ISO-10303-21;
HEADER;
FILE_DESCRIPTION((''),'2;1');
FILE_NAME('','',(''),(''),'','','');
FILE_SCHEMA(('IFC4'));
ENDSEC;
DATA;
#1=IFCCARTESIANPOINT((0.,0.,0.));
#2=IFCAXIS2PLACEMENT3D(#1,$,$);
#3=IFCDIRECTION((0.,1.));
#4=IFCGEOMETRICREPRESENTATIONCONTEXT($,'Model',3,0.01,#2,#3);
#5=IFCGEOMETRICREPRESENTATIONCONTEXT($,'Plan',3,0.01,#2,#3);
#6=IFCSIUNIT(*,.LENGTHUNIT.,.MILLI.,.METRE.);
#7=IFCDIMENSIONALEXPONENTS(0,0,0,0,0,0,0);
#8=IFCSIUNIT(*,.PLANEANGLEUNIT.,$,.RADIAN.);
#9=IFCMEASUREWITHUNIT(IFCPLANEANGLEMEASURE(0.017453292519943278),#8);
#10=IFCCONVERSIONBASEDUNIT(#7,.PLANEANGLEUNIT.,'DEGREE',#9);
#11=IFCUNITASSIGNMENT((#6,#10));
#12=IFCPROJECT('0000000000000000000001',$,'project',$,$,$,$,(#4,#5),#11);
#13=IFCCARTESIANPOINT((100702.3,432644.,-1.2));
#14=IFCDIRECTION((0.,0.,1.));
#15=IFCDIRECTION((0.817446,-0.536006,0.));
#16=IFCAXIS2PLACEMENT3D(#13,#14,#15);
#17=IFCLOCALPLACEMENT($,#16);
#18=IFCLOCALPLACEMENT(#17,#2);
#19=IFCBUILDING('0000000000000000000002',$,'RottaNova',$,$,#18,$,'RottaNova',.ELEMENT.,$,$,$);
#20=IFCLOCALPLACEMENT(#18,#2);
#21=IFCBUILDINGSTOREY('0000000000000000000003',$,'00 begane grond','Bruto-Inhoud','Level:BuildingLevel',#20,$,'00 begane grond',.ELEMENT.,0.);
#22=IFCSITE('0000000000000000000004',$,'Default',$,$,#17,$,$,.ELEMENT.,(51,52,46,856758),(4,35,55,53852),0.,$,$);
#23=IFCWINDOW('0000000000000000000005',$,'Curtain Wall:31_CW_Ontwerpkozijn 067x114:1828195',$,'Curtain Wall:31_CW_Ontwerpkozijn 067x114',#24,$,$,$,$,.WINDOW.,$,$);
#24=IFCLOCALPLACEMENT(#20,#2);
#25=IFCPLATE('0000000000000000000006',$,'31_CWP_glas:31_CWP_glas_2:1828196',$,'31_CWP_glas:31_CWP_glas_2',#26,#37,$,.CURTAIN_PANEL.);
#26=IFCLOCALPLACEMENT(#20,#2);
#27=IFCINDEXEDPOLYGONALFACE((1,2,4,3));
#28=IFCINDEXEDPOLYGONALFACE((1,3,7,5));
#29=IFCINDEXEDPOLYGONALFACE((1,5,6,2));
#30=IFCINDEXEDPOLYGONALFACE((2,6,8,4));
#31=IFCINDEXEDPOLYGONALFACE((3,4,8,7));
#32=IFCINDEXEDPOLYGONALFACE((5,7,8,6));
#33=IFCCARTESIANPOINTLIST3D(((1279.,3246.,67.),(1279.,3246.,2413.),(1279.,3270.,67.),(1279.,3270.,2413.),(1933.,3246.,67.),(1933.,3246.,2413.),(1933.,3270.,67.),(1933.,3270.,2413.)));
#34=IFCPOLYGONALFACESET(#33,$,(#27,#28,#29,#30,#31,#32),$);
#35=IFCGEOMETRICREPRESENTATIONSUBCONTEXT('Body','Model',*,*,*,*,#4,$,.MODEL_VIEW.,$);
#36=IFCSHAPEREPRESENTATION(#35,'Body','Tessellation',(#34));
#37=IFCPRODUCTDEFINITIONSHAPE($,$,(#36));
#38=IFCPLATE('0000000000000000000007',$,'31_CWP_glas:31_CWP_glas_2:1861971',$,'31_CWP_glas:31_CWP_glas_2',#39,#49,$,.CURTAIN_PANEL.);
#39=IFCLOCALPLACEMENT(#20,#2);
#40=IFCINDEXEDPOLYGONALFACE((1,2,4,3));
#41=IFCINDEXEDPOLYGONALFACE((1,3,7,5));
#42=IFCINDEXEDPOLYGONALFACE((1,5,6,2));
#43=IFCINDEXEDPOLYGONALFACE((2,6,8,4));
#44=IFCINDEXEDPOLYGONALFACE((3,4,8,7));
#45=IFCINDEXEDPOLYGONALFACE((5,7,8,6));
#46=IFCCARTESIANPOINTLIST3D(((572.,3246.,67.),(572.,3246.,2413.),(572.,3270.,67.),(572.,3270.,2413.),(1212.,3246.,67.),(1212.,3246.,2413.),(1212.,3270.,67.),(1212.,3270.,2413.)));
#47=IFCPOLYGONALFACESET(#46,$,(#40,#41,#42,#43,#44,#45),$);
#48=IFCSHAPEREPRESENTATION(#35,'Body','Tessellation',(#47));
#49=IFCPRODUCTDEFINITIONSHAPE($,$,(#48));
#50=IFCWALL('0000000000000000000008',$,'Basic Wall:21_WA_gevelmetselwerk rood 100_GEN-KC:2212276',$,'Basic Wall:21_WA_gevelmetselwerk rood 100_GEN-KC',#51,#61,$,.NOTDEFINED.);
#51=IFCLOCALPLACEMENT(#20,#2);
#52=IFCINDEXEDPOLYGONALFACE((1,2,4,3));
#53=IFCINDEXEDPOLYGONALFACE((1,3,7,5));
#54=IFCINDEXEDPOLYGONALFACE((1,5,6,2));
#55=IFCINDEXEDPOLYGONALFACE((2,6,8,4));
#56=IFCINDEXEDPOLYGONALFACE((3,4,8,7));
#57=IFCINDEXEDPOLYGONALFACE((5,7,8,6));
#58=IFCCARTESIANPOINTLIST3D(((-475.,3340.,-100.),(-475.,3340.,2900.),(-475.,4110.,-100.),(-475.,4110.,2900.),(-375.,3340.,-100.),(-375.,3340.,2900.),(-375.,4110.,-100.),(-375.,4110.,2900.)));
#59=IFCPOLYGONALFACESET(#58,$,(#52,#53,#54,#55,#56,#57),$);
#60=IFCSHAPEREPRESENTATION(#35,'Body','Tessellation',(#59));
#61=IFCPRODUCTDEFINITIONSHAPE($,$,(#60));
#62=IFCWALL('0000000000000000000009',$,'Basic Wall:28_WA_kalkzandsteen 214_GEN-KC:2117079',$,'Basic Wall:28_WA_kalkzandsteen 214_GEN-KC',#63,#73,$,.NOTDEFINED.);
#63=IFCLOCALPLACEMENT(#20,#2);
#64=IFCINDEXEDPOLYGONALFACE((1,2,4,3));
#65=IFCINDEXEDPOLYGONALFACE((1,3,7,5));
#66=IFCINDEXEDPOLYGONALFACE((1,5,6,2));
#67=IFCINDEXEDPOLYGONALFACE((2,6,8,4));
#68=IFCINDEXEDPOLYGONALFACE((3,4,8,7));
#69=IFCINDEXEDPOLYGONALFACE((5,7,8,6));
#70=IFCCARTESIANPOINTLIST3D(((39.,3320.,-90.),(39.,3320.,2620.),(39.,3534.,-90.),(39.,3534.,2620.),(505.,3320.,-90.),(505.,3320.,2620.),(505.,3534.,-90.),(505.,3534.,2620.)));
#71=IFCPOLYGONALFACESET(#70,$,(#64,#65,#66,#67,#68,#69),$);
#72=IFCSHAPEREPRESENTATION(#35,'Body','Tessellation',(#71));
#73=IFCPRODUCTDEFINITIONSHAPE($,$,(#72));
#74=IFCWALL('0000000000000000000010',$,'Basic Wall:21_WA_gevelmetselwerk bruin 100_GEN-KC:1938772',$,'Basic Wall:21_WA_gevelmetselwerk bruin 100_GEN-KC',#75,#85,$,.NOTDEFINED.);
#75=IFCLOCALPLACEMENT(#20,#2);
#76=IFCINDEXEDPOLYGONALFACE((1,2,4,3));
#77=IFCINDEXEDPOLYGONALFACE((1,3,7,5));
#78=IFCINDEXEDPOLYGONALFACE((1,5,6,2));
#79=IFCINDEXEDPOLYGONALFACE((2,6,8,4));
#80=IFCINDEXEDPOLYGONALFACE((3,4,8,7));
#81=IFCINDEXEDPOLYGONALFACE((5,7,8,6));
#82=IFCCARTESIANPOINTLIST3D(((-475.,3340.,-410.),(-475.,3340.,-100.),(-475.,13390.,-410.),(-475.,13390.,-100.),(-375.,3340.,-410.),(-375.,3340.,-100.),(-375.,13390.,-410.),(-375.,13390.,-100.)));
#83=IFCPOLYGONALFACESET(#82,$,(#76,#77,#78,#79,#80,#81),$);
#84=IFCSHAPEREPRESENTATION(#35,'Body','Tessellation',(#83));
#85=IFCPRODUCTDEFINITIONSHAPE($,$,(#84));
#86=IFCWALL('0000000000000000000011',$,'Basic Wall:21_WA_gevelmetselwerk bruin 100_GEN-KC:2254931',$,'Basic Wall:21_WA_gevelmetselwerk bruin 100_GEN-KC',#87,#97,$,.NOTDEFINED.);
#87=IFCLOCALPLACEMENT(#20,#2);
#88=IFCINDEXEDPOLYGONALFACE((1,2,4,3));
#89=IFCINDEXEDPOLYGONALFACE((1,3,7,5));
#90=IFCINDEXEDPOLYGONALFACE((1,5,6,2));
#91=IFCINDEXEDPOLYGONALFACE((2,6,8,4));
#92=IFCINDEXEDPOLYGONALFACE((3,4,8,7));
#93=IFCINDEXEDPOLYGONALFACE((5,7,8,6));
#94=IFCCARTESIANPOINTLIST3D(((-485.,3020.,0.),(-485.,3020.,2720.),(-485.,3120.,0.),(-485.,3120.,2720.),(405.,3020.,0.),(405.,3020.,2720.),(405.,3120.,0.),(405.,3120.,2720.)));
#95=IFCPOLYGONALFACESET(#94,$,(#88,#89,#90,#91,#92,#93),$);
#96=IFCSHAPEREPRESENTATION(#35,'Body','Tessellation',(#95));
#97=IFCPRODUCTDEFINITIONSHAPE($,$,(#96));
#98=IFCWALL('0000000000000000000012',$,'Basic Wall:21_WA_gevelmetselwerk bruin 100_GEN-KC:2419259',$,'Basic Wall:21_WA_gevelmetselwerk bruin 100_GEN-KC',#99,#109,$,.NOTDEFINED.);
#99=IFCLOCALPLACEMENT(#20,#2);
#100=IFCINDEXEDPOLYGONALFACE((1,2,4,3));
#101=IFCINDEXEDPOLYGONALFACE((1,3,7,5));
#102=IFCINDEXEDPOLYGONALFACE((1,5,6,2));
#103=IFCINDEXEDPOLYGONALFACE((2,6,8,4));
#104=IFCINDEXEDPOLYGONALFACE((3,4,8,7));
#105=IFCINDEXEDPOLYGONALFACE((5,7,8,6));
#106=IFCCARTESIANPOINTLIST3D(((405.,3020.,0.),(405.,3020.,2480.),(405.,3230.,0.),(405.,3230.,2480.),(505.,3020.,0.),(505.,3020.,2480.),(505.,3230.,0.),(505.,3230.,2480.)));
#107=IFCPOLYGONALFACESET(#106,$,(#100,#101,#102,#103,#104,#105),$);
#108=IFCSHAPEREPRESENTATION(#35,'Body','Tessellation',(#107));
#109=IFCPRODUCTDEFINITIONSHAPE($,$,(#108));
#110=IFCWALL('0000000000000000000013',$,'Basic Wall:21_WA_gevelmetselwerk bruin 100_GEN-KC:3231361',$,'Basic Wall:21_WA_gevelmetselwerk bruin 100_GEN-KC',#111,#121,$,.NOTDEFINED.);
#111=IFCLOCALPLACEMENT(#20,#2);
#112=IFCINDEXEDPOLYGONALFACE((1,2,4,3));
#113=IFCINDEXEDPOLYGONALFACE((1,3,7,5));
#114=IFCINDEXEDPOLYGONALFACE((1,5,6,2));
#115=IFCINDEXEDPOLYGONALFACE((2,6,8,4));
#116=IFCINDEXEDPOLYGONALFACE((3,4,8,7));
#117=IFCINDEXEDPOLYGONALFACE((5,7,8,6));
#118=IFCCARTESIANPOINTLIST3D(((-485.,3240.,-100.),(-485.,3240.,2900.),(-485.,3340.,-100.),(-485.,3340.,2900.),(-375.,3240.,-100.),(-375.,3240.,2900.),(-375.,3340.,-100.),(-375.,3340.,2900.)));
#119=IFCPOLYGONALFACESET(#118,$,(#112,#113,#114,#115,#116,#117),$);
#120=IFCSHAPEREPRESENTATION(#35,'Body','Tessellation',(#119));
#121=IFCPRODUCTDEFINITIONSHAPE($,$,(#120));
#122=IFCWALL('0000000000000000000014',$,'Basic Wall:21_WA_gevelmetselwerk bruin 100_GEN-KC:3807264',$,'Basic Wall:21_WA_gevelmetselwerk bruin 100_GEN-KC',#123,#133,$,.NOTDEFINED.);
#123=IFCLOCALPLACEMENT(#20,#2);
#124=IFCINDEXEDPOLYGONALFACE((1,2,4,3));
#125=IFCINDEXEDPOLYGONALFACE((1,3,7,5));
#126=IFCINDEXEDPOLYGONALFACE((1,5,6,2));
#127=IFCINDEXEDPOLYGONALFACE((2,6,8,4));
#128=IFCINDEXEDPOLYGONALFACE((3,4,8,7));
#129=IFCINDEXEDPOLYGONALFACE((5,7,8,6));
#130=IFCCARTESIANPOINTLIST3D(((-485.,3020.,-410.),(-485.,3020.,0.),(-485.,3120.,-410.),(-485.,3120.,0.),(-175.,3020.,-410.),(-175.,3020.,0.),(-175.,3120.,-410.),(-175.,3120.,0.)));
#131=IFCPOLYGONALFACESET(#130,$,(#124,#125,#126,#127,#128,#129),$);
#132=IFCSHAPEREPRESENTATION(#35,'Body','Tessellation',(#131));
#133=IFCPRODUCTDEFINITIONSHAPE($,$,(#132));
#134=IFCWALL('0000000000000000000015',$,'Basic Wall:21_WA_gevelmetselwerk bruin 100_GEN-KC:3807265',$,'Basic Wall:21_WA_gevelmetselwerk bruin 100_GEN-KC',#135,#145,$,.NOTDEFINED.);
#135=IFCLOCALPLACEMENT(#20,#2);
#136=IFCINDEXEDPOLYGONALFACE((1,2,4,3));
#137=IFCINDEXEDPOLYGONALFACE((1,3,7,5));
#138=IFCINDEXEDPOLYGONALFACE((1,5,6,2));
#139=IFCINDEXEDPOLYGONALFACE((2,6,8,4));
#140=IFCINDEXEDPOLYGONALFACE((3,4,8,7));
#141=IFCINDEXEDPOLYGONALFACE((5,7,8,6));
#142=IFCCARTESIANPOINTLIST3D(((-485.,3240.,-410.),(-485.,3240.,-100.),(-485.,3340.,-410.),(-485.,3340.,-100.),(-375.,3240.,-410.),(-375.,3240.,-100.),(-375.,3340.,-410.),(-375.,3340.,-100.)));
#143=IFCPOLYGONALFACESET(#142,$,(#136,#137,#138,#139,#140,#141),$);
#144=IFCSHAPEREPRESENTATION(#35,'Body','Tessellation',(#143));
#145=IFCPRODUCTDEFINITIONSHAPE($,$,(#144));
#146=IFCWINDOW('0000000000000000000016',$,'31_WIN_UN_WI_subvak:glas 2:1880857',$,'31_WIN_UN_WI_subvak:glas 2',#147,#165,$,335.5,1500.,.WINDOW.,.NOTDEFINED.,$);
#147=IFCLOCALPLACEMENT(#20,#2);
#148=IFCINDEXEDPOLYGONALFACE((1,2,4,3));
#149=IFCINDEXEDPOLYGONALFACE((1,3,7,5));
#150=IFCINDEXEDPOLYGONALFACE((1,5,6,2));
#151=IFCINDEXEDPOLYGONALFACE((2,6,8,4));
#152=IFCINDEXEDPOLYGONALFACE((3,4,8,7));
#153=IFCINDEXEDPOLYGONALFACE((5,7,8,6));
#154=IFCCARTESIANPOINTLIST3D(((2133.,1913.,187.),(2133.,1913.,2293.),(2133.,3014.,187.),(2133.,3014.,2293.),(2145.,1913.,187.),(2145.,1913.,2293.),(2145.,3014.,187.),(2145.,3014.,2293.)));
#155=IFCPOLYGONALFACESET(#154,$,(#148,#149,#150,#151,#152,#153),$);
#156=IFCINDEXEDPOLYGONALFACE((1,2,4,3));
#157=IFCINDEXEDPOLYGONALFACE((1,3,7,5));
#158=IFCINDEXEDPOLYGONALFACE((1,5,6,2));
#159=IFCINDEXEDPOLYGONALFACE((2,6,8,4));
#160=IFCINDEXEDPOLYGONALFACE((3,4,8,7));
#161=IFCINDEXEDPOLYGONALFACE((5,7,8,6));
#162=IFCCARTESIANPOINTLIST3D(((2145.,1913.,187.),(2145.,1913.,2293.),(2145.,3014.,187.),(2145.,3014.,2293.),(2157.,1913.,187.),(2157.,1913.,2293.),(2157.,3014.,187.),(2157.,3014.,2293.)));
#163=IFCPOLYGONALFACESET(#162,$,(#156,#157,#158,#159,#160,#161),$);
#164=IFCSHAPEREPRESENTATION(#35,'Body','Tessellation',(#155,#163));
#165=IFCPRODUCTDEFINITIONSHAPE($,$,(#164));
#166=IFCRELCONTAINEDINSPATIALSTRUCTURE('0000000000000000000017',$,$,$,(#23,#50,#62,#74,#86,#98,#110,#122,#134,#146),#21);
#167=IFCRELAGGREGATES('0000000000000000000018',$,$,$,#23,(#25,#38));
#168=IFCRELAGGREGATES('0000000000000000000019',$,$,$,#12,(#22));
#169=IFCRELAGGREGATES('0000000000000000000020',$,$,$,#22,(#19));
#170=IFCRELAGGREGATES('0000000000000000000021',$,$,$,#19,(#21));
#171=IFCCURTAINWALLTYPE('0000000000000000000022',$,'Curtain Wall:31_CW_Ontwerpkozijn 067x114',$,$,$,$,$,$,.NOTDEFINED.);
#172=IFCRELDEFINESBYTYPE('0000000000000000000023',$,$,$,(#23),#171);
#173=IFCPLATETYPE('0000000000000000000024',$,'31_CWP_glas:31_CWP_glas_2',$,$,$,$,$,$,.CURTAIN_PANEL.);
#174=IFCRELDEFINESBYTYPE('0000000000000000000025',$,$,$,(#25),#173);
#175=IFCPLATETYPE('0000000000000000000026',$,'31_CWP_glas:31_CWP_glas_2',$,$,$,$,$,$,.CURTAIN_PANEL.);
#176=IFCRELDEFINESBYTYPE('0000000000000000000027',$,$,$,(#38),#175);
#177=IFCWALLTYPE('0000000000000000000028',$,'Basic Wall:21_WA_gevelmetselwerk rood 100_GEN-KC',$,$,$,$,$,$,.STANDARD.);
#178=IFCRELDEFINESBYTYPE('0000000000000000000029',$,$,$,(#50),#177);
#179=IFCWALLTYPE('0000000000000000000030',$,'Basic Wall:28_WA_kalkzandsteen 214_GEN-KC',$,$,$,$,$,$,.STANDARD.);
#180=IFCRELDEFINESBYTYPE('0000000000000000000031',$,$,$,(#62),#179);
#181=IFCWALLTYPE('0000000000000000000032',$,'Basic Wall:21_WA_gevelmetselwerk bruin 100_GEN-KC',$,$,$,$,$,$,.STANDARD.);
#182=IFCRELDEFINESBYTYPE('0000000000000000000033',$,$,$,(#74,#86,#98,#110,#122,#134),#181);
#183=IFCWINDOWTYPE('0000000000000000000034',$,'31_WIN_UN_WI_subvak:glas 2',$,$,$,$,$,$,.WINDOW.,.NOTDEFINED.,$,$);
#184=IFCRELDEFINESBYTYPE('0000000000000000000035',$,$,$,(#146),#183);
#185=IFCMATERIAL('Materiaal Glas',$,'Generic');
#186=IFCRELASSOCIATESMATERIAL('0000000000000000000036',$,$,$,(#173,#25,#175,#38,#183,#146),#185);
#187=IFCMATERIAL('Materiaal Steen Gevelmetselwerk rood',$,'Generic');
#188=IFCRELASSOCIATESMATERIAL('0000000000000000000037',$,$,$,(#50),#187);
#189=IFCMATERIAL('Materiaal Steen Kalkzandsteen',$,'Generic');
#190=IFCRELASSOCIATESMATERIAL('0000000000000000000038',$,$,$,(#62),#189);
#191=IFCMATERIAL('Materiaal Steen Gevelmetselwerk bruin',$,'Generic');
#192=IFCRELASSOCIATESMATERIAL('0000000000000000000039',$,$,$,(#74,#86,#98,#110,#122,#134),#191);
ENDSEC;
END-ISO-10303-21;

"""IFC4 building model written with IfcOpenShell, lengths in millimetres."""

from ifc_helpers import new_model, entity, si_unit, converted_unit, direction, frame, origin, place, context, subcontext, project, spatial, indexed_curve, outline, extrude, source, transform, mapped, material, type_object, type_shapes, element, aggregate, save


model = new_model("IFC4")

# Units and contexts
model_context = context("Model", 3, precision=0.01, world=origin(), true_north=direction((0.0, 1.0)))
plan_context = context("Plan", 3, precision=0.01, world=origin(), true_north=direction((0.0, 1.0)))
body_context = subcontext(model_context, "Body", "Model", "MODEL_VIEW")
ifc_project = project(units=[si_unit("LENGTHUNIT", "METRE", prefix="MILLI"), converted_unit("PLANEANGLEUNIT", "DEGREE", entity("IfcPlaneAngleMeasure", 0.017453292519943278), si_unit("PLANEANGLEUNIT", "RADIAN"), dimensions=[0, 0, 0, 0, 0, 0, 0])], contexts=[model_context, plan_context])

# Site, building, storey
site_placement = place(None, frame((100702.3, 432644.0, -1.2), z_axis=(0.0, 0.0, 1.0), x_axis=(0.817446, -0.536006, 0.0)))
site = spatial("IfcSite", under=ifc_project, at=site_placement, Name="Default", CompositionType="ELEMENT", RefLatitude=(51, 52, 46, 856758), RefLongitude=(4, 35, 55, 53852), RefElevation=0.0)
building_placement = place(site_placement, origin())
building = spatial("IfcBuilding", under=site, at=building_placement, Name="RottaNova", LongName="RottaNova", CompositionType="ELEMENT")
storey_placement = place(building_placement, origin())
storey = spatial("IfcBuildingStorey", under=building, at=storey_placement, Name="00 begane grond", Description="Bruto-Inhoud", ObjectType="Level:BuildingLevel", LongName="00 begane grond", CompositionType="ELEMENT", Elevation=0.0)

# Window
curtain_wall_type = type_object("IfcCurtainWallType", Name="Curtain Wall:31_CW_Ontwerpkozijn 067x114", PredefinedType="NOTDEFINED")
window_1_placement = place(storey_placement, origin())
window_1 = element("IfcWindow", 1, at=window_1_placement, inside=storey, type_object=curtain_wall_type, Name="Curtain Wall:31_CW_Ontwerpkozijn 067x114:1828195", ObjectType="Curtain Wall:31_CW_Ontwerpkozijn 067x114", PredefinedType="WINDOW")

# Plates
ifc_material_1 = material(Name="Materiaal Glas", Category="Generic")
plate_type_1 = type_object("IfcPlateType", Name="31_CWP_glas:31_CWP_glas_2", PredefinedType="CURTAIN_PANEL", material=ifc_material_1)
shared_shape_1 = source(origin(), body_context, "Body", "SweptSolid", [
    extrude(outline(indexed_curve([(-12.0, -327.0), (12.0, -327.0), (12.0, 327.0), (-12.0, 327.0), (-12.0, -327.0)], self_intersect=False)), frame((0.0, 57.0, 0.0), z_axis=(0.0, 0.0, 1.0), x_axis=(0.0, 1.0, 0.0)), (0.0, 0.0, 1.0), 2346.0),
])
type_shapes(plate_type_1, [shared_shape_1])
plate_1_placement = place(window_1_placement, frame((1606.0, 3315.0, 67.0), z_axis=(0.0, 0.0, 1.0), x_axis=(-1.0, 0.0, 0.0)))
plate_1 = element("IfcPlate", 2, at=plate_1_placement, type_object=plate_type_1, material=ifc_material_1, Name="31_CWP_glas:31_CWP_glas_2:1828196", ObjectType="31_CWP_glas:31_CWP_glas_2", PredefinedType="CURTAIN_PANEL", context=body_context, shape_type="MappedRepresentation", body=[
    mapped(shared_shape_1, transform((0.0, 0.0, 0.0), scale=1.0)),
])
plate_type_2 = type_object("IfcPlateType", Name="31_CWP_glas:31_CWP_glas_2", PredefinedType="CURTAIN_PANEL", material=ifc_material_1)
shared_shape_2 = source(origin(), body_context, "Body", "SweptSolid", [
    extrude(outline(indexed_curve([(-12.0, -320.0), (12.0, -320.0), (12.0, 320.0), (-12.0, 320.0), (-12.0, -320.0)], self_intersect=False)), frame((0.0, 57.0, 0.0), z_axis=(0.0, 0.0, 1.0), x_axis=(0.0, 1.0, 0.0)), (0.0, 0.0, 1.0), 2346.0),
])
type_shapes(plate_type_2, [shared_shape_2])
plate_2_placement = place(window_1_placement, frame((892.0, 3315.0, 67.0), z_axis=(0.0, 0.0, 1.0), x_axis=(-1.0, 0.0, 0.0)))
plate_2 = element("IfcPlate", 3, at=plate_2_placement, type_object=plate_type_2, material=ifc_material_1, Name="31_CWP_glas:31_CWP_glas_2:1861971", ObjectType="31_CWP_glas:31_CWP_glas_2", PredefinedType="CURTAIN_PANEL", context=body_context, shape_type="MappedRepresentation", body=[
    mapped(shared_shape_2, transform((0.0, 0.0, 0.0), scale=1.0)),
])
aggregate(window_1, [plate_1, plate_2])

# Walls
ifc_material_2 = material(Name="Materiaal Steen Gevelmetselwerk rood", Category="Generic")
wall_type_1 = type_object("IfcWallType", Name="Basic Wall:21_WA_gevelmetselwerk rood 100_GEN-KC", PredefinedType="STANDARD")
wall_1_placement = place(storey_placement, frame((-425.0, 3340.0, -100.0), z_axis=(0.0, 0.0, 1.0), x_axis=(0.0, 1.0, 0.0)))
element("IfcWall", 4, at=wall_1_placement, inside=storey, type_object=wall_type_1, material=ifc_material_2, Name="Basic Wall:21_WA_gevelmetselwerk rood 100_GEN-KC:2212276", ObjectType="Basic Wall:21_WA_gevelmetselwerk rood 100_GEN-KC", PredefinedType="NOTDEFINED", context=body_context, shape_type="SweptSolid", body=[
    extrude(outline(indexed_curve([(770.0, 50.0), (0.0, 50.0), (0.0, -50.0), (770.0, -50.0), (770.0, 50.0)], self_intersect=False)), origin(), (0.0, 0.0, 1.0), 3000.0),
])
ifc_material_3 = material(Name="Materiaal Steen Kalkzandsteen", Category="Generic")
wall_type_2 = type_object("IfcWallType", Name="Basic Wall:28_WA_kalkzandsteen 214_GEN-KC", PredefinedType="STANDARD")
wall_2_placement = place(storey_placement, frame((39.0, 3427.0, -90.0)))
element("IfcWall", 5, at=wall_2_placement, inside=storey, type_object=wall_type_2, material=ifc_material_3, Name="Basic Wall:28_WA_kalkzandsteen 214_GEN-KC:2117079", ObjectType="Basic Wall:28_WA_kalkzandsteen 214_GEN-KC", PredefinedType="NOTDEFINED", context=body_context, shape_type="SweptSolid", body=[
    extrude(outline(indexed_curve([(466.0, 107.0), (0.0, 107.0), (0.0, -107.0), (466.0, -107.0), (466.0, 107.0)], self_intersect=False)), origin(), (0.0, 0.0, 1.0), 2710.0),
])
ifc_material_4 = material(Name="Materiaal Steen Gevelmetselwerk bruin", Category="Generic")
wall_type_3 = type_object("IfcWallType", Name="Basic Wall:21_WA_gevelmetselwerk bruin 100_GEN-KC", PredefinedType="STANDARD")
wall_3_placement = place(storey_placement, frame((-425.0, 3340.0, -410.0), z_axis=(0.0, 0.0, 1.0), x_axis=(0.0, 1.0, 0.0)))
element("IfcWall", 6, at=wall_3_placement, inside=storey, type_object=wall_type_3, material=ifc_material_4, Name="Basic Wall:21_WA_gevelmetselwerk bruin 100_GEN-KC:1938772", ObjectType="Basic Wall:21_WA_gevelmetselwerk bruin 100_GEN-KC", PredefinedType="NOTDEFINED", context=body_context, shape_type="SweptSolid", body=[
    extrude(outline(indexed_curve([(10050.0, 50.0), (0.0, 50.0), (0.0, -50.0), (10050.0, -50.0), (10050.0, 50.0)], self_intersect=False)), origin(), (0.0, 0.0, 1.0), 310.0),
])
wall_4_placement = place(storey_placement, frame((405.0, 3070.0, 0.0), z_axis=(0.0, 0.0, 1.0), x_axis=(-1.0, 0.0, 0.0)))
element("IfcWall", 7, at=wall_4_placement, inside=storey, type_object=wall_type_3, material=ifc_material_4, Name="Basic Wall:21_WA_gevelmetselwerk bruin 100_GEN-KC:2254931", ObjectType="Basic Wall:21_WA_gevelmetselwerk bruin 100_GEN-KC", PredefinedType="NOTDEFINED", context=body_context, shape_type="SweptSolid", body=[
    extrude(outline(indexed_curve([(890.0, 50.0), (0.0, 50.0), (0.0, -50.0), (890.0, -50.0), (890.0, 50.0)], self_intersect=False)), origin(), (0.0, 0.0, 1.0), 2720.0),
])
wall_5_placement = place(storey_placement, frame((455.0, 3230.0, 0.0), z_axis=(0.0, 0.0, 1.0), x_axis=(0.0, -1.0, 0.0)))
element("IfcWall", 8, at=wall_5_placement, inside=storey, type_object=wall_type_3, material=ifc_material_4, Name="Basic Wall:21_WA_gevelmetselwerk bruin 100_GEN-KC:2419259", ObjectType="Basic Wall:21_WA_gevelmetselwerk bruin 100_GEN-KC", PredefinedType="NOTDEFINED", context=body_context, shape_type="SweptSolid", body=[
    extrude(outline(indexed_curve([(210.0, 50.0), (0.0, 50.0), (0.0, -50.0), (210.0, -50.0), (210.0, 50.0)], self_intersect=False)), origin(), (0.0, 0.0, 1.0), 2480.0),
])
wall_6_placement = place(storey_placement, frame((-485.0, 3290.0, -100.0)))
element("IfcWall", 9, at=wall_6_placement, inside=storey, type_object=wall_type_3, material=ifc_material_4, Name="Basic Wall:21_WA_gevelmetselwerk bruin 100_GEN-KC:3231361", ObjectType="Basic Wall:21_WA_gevelmetselwerk bruin 100_GEN-KC", PredefinedType="NOTDEFINED", context=body_context, shape_type="SweptSolid", body=[
    extrude(outline(indexed_curve([(110.0, 50.0), (0.0, 50.0), (0.0, -50.0), (110.0, -50.0), (110.0, 50.0)], self_intersect=False)), origin(), (0.0, 0.0, 1.0), 3000.0),
])
wall_7_placement = place(storey_placement, frame((-175.0, 3070.0, -410.0), z_axis=(0.0, 0.0, 1.0), x_axis=(-1.0, 0.0, 0.0)))
element("IfcWall", 10, at=wall_7_placement, inside=storey, type_object=wall_type_3, material=ifc_material_4, Name="Basic Wall:21_WA_gevelmetselwerk bruin 100_GEN-KC:3807264", ObjectType="Basic Wall:21_WA_gevelmetselwerk bruin 100_GEN-KC", PredefinedType="NOTDEFINED", context=body_context, shape_type="SweptSolid", body=[
    extrude(outline(indexed_curve([(310.0, 50.0), (0.0, 50.0), (0.0, -50.0), (310.0, -50.0), (310.0, 50.0)], self_intersect=False)), origin(), (0.0, 0.0, 1.0), 410.0),
])
wall_8_placement = place(storey_placement, frame((-485.0, 3290.0, -410.0)))
element("IfcWall", 11, at=wall_8_placement, inside=storey, type_object=wall_type_3, material=ifc_material_4, Name="Basic Wall:21_WA_gevelmetselwerk bruin 100_GEN-KC:3807265", ObjectType="Basic Wall:21_WA_gevelmetselwerk bruin 100_GEN-KC", PredefinedType="NOTDEFINED", context=body_context, shape_type="SweptSolid", body=[
    extrude(outline(indexed_curve([(110.0, 50.0), (0.0, 50.0), (0.0, -50.0), (110.0, -50.0), (110.0, 50.0)], self_intersect=False)), origin(), (0.0, 0.0, 1.0), 310.0),
])

# Window
window_type = type_object("IfcWindowType", Name="31_WIN_UN_WI_subvak:glas 2", PartitioningType="NOTDEFINED", PredefinedType="WINDOW", material=ifc_material_1)
shared_shape_3 = source(origin(), body_context, "Body", "SweptSolid", [
    extrude(outline(indexed_curve([(-6.0, -550.5), (6.0, -550.5), (6.0, 550.5), (-6.0, 550.5), (-6.0, -550.5)], self_intersect=False)), frame((0.0, 6.0, 0.0), z_axis=(0.0, 0.0, 1.0), x_axis=(0.0, -1.0, 0.0)), (0.0, 0.0, 1.0), 2106.0),
    extrude(outline(indexed_curve([(-6.0, -550.5), (6.0, -550.5), (6.0, 550.5), (-6.0, 550.5), (-6.0, -550.5)], self_intersect=False)), frame((0.0, -6.0, 0.0), z_axis=(0.0, 0.0, 1.0), x_axis=(0.0, -1.0, 0.0)), (0.0, 0.0, 1.0), 2106.0),
])
type_shapes(window_type, [shared_shape_3])
window_2_placement = place(storey_placement, frame((2145.0, 2463.5, 187.0), z_axis=(0.0, 0.0, 1.0), x_axis=(0.0, 1.0, 0.0)))
element("IfcWindow", 12, at=window_2_placement, inside=storey, type_object=window_type, material=ifc_material_1, Name="31_WIN_UN_WI_subvak:glas 2:1880857", ObjectType="31_WIN_UN_WI_subvak:glas 2", OverallHeight=335.5, OverallWidth=1500.0, PartitioningType="NOTDEFINED", PredefinedType="WINDOW", context=body_context, shape_type="MappedRepresentation", body=[
    mapped(shared_shape_3, transform((0.0, 0.0, 0.0), scale=1.0)),
])

save(model, "model.ifc")
